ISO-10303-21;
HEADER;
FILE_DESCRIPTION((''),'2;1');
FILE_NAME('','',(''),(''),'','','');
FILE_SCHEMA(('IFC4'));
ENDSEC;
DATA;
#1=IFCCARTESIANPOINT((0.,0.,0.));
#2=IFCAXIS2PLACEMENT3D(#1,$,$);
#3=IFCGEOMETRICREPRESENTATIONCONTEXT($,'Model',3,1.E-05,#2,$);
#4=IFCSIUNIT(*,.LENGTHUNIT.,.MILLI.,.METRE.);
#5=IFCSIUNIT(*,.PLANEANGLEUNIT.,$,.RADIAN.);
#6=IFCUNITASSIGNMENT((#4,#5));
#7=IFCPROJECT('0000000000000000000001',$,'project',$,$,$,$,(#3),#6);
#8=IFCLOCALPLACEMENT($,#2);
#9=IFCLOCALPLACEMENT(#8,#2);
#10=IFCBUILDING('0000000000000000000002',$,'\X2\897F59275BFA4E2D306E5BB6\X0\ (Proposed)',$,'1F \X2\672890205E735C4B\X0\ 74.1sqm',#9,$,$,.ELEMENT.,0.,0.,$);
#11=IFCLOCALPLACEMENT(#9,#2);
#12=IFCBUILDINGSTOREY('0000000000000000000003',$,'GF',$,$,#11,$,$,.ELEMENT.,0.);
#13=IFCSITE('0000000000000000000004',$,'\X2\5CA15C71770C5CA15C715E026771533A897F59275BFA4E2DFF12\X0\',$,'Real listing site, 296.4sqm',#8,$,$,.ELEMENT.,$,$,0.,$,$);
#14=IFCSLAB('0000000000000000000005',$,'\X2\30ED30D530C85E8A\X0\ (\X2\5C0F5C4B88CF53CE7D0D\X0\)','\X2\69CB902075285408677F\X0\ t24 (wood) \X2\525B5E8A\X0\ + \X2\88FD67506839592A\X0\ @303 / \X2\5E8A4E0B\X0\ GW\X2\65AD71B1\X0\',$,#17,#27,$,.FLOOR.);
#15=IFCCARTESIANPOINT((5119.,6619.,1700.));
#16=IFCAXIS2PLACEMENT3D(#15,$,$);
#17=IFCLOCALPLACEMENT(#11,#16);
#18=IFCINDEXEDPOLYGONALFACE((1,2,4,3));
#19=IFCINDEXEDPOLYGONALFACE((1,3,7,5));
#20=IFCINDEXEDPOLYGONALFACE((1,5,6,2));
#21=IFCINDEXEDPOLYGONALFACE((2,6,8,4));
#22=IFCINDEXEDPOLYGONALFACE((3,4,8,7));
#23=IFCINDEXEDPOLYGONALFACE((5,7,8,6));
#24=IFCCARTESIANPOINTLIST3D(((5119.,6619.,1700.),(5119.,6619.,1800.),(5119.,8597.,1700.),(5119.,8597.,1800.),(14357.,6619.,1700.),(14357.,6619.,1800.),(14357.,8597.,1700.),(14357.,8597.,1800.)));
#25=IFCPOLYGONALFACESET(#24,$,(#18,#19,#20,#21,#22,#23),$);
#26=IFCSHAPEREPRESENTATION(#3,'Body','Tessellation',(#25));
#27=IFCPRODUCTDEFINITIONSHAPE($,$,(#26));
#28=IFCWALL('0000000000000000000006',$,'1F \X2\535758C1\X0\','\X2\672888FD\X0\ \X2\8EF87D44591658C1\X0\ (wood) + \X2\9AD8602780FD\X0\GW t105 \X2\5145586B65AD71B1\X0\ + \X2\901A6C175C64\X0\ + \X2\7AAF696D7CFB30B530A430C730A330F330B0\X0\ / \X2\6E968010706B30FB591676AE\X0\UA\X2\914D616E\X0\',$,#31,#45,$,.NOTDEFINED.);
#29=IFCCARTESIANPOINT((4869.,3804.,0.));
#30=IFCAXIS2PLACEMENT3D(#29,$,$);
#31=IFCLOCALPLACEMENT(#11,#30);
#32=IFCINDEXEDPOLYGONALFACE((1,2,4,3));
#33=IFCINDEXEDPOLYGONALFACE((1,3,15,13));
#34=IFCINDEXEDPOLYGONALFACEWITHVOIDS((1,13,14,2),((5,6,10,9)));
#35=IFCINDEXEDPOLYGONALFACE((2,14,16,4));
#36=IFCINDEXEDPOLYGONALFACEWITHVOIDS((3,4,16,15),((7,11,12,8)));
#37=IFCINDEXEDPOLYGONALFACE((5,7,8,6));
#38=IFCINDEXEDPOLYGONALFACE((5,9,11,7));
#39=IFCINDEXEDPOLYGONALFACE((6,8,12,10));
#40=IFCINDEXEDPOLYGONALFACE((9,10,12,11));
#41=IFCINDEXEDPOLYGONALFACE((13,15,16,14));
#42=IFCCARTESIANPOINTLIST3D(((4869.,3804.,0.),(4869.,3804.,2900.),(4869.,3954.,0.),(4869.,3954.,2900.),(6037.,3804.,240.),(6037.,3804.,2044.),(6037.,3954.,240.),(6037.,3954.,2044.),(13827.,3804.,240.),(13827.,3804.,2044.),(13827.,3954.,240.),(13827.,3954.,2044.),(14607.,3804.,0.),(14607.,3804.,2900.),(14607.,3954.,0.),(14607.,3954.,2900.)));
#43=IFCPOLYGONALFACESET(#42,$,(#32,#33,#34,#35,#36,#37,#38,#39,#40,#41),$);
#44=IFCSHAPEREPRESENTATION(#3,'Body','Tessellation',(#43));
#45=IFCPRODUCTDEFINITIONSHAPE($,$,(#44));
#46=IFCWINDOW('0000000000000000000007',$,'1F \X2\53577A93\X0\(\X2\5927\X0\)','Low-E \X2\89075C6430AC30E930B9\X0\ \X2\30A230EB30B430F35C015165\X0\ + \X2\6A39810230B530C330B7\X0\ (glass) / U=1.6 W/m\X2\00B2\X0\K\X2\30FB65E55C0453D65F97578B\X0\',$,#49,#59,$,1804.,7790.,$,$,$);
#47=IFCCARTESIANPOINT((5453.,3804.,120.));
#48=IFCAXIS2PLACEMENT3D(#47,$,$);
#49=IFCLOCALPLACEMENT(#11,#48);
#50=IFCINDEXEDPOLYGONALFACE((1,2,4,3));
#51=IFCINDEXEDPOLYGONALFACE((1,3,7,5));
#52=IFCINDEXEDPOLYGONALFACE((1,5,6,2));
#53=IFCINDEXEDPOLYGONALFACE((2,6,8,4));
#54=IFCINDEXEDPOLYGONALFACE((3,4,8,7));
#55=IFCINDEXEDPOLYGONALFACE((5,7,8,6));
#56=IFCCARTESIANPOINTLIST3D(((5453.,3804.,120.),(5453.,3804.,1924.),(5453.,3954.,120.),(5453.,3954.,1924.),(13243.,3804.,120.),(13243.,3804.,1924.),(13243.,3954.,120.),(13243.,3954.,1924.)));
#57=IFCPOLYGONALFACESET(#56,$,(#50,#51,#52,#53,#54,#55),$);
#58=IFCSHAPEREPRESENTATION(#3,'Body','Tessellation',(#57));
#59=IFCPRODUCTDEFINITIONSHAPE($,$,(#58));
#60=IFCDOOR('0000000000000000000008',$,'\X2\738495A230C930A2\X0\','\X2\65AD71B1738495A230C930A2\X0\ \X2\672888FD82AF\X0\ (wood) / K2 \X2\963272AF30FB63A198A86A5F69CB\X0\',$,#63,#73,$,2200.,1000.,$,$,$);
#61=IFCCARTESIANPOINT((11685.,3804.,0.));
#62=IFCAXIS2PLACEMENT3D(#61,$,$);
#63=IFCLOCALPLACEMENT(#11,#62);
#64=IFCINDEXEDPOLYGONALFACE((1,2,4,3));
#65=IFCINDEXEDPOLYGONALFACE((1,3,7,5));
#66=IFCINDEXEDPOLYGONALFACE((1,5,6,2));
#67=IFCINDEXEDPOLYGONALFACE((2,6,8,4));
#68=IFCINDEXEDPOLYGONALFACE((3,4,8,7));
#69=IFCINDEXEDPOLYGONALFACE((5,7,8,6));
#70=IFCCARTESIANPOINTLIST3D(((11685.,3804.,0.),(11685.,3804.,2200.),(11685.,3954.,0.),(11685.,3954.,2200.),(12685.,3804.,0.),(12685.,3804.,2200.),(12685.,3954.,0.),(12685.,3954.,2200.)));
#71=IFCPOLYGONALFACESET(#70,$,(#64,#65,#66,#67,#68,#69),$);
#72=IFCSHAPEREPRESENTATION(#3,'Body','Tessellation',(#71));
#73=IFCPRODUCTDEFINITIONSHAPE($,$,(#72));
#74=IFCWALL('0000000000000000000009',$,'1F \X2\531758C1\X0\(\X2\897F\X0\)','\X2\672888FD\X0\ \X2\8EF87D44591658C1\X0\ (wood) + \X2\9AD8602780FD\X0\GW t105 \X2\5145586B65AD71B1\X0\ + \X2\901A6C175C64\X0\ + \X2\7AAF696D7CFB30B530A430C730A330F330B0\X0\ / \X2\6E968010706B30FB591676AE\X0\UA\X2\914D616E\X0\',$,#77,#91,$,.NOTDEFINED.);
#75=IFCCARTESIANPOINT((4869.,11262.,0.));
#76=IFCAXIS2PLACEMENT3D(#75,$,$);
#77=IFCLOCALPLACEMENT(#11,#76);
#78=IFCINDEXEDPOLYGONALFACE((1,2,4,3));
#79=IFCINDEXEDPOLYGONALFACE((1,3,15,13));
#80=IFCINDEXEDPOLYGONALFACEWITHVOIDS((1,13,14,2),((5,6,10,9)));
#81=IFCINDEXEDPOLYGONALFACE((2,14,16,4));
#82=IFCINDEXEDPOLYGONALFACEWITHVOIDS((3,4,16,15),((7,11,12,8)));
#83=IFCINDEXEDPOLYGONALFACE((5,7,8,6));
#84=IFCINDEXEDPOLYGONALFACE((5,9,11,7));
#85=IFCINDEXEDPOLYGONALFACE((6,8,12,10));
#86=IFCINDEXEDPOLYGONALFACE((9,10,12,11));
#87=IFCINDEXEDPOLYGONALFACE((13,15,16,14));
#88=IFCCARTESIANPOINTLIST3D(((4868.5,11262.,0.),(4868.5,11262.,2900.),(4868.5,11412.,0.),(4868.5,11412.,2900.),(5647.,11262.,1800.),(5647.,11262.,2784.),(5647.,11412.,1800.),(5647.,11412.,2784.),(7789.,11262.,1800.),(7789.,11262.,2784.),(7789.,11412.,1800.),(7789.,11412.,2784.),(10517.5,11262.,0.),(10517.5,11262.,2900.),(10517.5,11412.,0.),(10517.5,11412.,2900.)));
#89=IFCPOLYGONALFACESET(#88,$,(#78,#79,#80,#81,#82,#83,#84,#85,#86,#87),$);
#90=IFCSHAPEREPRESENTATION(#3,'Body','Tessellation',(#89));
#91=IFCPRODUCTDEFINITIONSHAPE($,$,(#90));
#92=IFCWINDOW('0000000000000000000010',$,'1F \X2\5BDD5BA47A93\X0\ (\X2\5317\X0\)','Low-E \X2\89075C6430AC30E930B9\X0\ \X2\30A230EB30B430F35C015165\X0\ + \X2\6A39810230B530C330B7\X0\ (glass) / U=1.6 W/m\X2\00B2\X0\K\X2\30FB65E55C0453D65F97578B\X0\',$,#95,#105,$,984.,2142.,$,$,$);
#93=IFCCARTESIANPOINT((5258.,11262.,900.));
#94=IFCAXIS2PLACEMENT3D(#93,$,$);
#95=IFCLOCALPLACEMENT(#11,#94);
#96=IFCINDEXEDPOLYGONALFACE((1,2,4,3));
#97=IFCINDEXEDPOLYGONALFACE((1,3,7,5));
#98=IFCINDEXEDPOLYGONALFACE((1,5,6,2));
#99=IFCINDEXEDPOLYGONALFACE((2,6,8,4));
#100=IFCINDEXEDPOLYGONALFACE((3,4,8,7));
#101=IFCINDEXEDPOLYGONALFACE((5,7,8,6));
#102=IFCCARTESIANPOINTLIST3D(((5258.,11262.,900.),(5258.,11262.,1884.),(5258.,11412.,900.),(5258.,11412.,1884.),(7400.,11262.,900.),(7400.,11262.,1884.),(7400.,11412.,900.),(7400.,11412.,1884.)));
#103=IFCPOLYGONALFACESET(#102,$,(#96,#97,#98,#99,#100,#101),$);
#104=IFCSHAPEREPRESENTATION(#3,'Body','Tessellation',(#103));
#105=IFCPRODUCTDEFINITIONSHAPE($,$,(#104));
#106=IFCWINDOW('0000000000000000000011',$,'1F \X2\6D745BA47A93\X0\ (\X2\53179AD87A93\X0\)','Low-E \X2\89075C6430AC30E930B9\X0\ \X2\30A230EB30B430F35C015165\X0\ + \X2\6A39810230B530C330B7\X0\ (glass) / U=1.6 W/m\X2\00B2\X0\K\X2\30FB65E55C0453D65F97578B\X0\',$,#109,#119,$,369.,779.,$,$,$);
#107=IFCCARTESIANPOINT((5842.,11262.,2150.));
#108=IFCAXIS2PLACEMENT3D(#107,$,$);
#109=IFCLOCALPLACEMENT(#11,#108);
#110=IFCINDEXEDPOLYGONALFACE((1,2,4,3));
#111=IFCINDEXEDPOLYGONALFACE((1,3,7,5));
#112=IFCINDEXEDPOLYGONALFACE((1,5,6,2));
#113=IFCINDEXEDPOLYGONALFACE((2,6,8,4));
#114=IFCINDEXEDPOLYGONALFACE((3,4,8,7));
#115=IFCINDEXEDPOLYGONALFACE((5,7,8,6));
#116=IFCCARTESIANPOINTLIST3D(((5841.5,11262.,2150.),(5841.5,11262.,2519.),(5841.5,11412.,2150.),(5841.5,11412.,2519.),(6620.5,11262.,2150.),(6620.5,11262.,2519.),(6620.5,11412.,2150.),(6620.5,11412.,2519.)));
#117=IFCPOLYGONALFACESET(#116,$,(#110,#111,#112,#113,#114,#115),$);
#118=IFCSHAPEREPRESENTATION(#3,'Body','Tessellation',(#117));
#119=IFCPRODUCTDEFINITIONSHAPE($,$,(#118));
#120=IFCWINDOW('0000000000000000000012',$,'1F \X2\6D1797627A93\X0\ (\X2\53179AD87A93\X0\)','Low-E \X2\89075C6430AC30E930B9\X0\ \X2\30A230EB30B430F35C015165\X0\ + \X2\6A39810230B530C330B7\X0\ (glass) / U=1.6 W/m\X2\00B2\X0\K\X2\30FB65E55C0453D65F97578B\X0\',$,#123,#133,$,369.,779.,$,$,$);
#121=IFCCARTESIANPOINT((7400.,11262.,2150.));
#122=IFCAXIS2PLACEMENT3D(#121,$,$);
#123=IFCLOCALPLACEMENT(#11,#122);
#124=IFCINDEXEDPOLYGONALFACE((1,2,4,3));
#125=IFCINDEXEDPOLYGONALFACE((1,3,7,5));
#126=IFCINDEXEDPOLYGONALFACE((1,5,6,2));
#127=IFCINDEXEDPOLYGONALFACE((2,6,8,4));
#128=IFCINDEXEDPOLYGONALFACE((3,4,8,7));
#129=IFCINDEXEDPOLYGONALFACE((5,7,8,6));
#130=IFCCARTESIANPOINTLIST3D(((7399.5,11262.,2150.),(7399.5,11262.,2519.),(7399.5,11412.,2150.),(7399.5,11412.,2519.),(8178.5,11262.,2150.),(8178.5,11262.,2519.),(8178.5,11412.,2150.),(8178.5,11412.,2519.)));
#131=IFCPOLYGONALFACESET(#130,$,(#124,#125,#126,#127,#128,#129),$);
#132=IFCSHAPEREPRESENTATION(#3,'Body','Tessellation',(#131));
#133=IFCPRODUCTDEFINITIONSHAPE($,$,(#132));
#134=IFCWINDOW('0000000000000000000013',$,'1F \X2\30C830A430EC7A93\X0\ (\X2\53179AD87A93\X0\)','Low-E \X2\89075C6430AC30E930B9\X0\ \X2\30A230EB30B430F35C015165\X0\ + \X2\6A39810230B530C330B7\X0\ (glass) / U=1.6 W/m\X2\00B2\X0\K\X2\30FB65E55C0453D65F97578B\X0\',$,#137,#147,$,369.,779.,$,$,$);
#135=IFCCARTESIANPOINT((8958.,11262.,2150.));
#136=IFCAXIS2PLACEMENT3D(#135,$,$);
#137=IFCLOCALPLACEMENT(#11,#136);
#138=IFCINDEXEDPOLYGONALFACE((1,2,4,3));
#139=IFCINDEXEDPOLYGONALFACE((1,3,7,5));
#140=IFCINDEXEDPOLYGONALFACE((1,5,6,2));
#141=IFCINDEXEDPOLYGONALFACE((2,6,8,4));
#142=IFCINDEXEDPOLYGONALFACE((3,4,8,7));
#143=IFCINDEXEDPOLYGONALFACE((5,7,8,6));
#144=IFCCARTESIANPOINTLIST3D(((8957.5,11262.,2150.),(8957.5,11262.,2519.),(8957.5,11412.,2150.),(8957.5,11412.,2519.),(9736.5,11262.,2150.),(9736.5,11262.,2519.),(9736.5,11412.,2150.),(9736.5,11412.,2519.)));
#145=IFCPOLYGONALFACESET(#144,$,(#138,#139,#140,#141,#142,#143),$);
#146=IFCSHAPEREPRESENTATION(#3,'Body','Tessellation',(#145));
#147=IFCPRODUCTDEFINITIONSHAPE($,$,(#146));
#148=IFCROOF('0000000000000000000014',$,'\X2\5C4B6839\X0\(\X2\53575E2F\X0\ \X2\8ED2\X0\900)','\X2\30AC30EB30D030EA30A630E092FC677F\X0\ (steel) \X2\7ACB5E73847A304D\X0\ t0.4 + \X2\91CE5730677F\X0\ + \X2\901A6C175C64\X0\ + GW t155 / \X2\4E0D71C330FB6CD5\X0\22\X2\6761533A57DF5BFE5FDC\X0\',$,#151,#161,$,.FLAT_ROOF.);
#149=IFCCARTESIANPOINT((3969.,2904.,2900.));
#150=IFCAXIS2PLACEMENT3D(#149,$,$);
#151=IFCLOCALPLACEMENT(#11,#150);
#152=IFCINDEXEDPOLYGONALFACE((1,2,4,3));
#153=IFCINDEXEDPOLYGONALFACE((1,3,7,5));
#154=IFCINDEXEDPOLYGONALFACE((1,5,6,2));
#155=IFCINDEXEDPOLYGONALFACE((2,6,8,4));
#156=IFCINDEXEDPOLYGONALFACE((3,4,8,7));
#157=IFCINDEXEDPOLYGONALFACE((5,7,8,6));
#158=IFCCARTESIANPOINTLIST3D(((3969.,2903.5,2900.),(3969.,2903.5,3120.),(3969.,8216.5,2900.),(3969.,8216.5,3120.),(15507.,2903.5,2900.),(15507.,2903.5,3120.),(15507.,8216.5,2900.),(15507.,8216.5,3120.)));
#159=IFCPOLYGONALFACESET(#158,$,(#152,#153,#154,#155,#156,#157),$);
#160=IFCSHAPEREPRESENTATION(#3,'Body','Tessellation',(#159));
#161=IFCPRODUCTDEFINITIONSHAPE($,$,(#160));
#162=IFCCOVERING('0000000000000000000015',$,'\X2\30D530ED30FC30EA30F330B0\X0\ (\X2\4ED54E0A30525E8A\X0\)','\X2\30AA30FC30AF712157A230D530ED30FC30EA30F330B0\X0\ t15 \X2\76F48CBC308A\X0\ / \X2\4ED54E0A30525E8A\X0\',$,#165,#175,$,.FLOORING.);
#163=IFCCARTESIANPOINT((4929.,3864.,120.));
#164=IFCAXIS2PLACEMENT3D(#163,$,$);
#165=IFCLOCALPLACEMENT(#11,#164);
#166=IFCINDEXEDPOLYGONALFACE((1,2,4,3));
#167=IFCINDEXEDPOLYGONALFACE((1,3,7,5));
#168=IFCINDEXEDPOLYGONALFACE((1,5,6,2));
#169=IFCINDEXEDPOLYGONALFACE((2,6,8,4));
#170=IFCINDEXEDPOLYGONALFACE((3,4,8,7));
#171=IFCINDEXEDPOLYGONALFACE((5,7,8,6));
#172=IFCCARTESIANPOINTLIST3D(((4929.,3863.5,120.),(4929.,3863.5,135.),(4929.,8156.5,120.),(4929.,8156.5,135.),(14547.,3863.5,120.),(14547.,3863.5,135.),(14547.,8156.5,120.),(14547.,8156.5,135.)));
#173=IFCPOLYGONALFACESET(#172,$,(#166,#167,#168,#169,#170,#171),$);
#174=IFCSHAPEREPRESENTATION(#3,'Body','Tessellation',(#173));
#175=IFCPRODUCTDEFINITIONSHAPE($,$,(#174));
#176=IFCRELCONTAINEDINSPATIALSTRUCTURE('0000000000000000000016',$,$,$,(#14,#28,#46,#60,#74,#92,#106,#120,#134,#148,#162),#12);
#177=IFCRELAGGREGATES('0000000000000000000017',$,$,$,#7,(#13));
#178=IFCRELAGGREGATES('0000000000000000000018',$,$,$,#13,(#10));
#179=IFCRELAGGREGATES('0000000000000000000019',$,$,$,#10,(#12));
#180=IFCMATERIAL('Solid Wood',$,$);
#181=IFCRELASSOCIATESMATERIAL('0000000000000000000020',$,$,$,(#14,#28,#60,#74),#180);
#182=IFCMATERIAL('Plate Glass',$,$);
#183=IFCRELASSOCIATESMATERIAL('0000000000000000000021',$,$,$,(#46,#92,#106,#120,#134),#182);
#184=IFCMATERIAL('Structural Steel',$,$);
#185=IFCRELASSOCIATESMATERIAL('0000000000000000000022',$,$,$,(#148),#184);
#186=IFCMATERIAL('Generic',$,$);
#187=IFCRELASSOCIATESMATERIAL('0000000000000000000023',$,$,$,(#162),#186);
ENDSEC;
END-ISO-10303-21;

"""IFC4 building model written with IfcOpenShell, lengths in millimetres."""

from ifc_helpers import new_model, si_unit, frame, frame_2d, origin, place, context, project, spatial, rectangle, extrude, material, element, fill, save


model = new_model("IFC4")

# Units and contexts
model_context = context("Model", 3, precision=1e-05, world=origin())
ifc_project = project(units=[si_unit("LENGTHUNIT", "METRE", prefix="MILLI"), si_unit("PLANEANGLEUNIT", "RADIAN")], contexts=[model_context])

# Site, building, storey
site_placement = place(None, origin())
site = spatial("IfcSite", under=ifc_project, at=site_placement, Name="岡山県岡山市東区西大寺中２", ObjectType="Real listing site, 296.4sqm", CompositionType="ELEMENT", RefElevation=0.0)
building_placement = place(site_placement, origin())
building = spatial("IfcBuilding", under=site, at=building_placement, Name="西大寺中の家 (Proposed)", ObjectType="1F 木造平屋 74.1sqm", CompositionType="ELEMENT", ElevationOfRefHeight=0.0, ElevationOfTerrain=0.0)
storey_placement = place(building_placement, origin())
storey = spatial("IfcBuildingStorey", under=building, at=storey_placement, Name="GF", CompositionType="ELEMENT", Elevation=0.0)

# Slab
ifc_material_1 = material(Name="Solid Wood")
slab_1_placement = place(storey_placement, frame((5119.0, 6619.0, 1700.0)))
element("IfcSlab", 1, at=slab_1_placement, inside=storey, material=ifc_material_1, Name="ロフト床 (小屋裏収納)", Description="構造用合板 t24 (wood) 剛床 + 製材根太 @303 / 床下 GW断熱", PredefinedType="FLOOR", context=model_context, shape_type="SweptSolid", body=[
    extrude(rectangle(XDim=9238.0, YDim=1978.0, at=frame_2d((4619.0, 989.0))), frame((5119.0, 6619.0, 1700.0)), (0.0, 0.0, 1.0), 100.0),
])

# Wall, openings, window, door
wall_1_placement = place(storey_placement, frame((4869.0, 3804.0, 0.0)))
wall_1 = element("IfcWall", 2, at=wall_1_placement, inside=storey, material=ifc_material_1, Name="1F 南壁", Description="木製 軸組外壁 (wood) + 高性能GW t105 充填断熱 + 通気層 + 窯業系サイディング / 準耐火・外皮UA配慮", PredefinedType="NOTDEFINED", context=model_context, shape_type="SweptSolid", body=[
    extrude(rectangle(XDim=9738.0, YDim=150.0, at=frame_2d((4869.0, 75.0))), frame((4869.0, 3804.0, 0.0)), (0.0, 0.0, 1.0), 2900.0),
])
opening_1_placement = place(storey_placement, frame((5453.0, 3804.0, 120.0)))
opening_1 = element("IfcOpeningElement", 3, at=opening_1_placement, cuts=wall_1, PredefinedType="NOTDEFINED", context=model_context, shape_type="SweptSolid", body=[
    extrude(rectangle(XDim=7790.0, YDim=150.0, at=frame_2d((3895.0, 75.0))), frame((5453.0, 3804.0, 120.0)), (0.0, 0.0, 1.0), 1804.0),
])
opening_2_placement = place(storey_placement, frame((11685.0, 3804.0, 0.0)))
opening_2 = element("IfcOpeningElement", 4, at=opening_2_placement, cuts=wall_1, PredefinedType="NOTDEFINED", context=model_context, shape_type="SweptSolid", body=[
    extrude(rectangle(XDim=1000.0, YDim=150.0, at=frame_2d((500.0, 75.0))), frame((11685.0, 3804.0, 0.0)), (0.0, 0.0, 1.0), 2200.0),
])
ifc_material_2 = material(Name="Plate Glass")
window_1_placement = place(storey_placement, frame((5453.0, 3804.0, 120.0)))
window_1 = element("IfcWindow", 5, at=window_1_placement, inside=storey, material=ifc_material_2, Name="1F 南窓(大)", Description="Low-E 複層ガラス アルゴン封入 + 樹脂サッシ (glass) / U=1.6 W/m²K・日射取得型", OverallHeight=1804.0, OverallWidth=7790.0, context=model_context, shape_type="SweptSolid", body=[
    extrude(rectangle(XDim=7790.0, YDim=150.0, at=frame_2d((3895.0, 75.0))), frame((5453.0, 3804.0, 120.0)), (0.0, 0.0, 1.0), 1804.0),
])
fill(opening_1, window_1)
door_placement = place(storey_placement, frame((11685.0, 3804.0, 0.0)))
door = element("IfcDoor", 6, at=door_placement, inside=storey, material=ifc_material_1, Name="玄関ドア", Description="断熱玄関ドア 木製芯 (wood) / K2 防犯・採風機構", OverallHeight=2200.0, OverallWidth=1000.0, context=model_context, shape_type="SweptSolid", body=[
    extrude(rectangle(XDim=1000.0, YDim=150.0, at=frame_2d((500.0, 75.0))), frame((11685.0, 3804.0, 0.0)), (0.0, 0.0, 1.0), 2200.0),
])
fill(opening_2, door)

# Wall, openings, windows
wall_2_placement = place(storey_placement, frame((4869.0, 11262.0, 0.0)))
wall_2 = element("IfcWall", 7, at=wall_2_placement, inside=storey, material=ifc_material_1, Name="1F 北壁(西)", Description="木製 軸組外壁 (wood) + 高性能GW t105 充填断熱 + 通気層 + 窯業系サイディング / 準耐火・外皮UA配慮", PredefinedType="NOTDEFINED", context=model_context, shape_type="SweptSolid", body=[
    extrude(rectangle(XDim=5649.0, YDim=150.0, at=frame_2d((2824.0, 75.0))), frame((4869.0, 11262.0, 0.0)), (0.0, 0.0, 1.0), 2900.0),
])
opening_3_placement = place(storey_placement, frame((5258.0, 11262.0, 900.0)))
opening_3 = element("IfcOpeningElement", 8, at=opening_3_placement, cuts=wall_2, PredefinedType="NOTDEFINED", context=model_context, shape_type="SweptSolid", body=[
    extrude(rectangle(XDim=2142.0, YDim=150.0, at=frame_2d((1071.0, 75.0))), frame((5258.0, 11262.0, 900.0)), (0.0, 0.0, 1.0), 984.0),
])
opening_4_placement = place(storey_placement, frame((5842.0, 11262.0, 2150.0)))
opening_4 = element("IfcOpeningElement", 9, at=opening_4_placement, cuts=wall_2, PredefinedType="NOTDEFINED", context=model_context, shape_type="SweptSolid", body=[
    extrude(rectangle(XDim=779.0, YDim=150.0, at=frame_2d((389.0, 75.0))), frame((5842.0, 11262.0, 2150.0)), (0.0, 0.0, 1.0), 369.0),
])
opening_5_placement = place(storey_placement, frame((7400.0, 11262.0, 2150.0)))
opening_5 = element("IfcOpeningElement", 10, at=opening_5_placement, cuts=wall_2, PredefinedType="NOTDEFINED", context=model_context, shape_type="SweptSolid", body=[
    extrude(rectangle(XDim=779.0, YDim=150.0, at=frame_2d((389.0, 75.0))), frame((7400.0, 11262.0, 2150.0)), (0.0, 0.0, 1.0), 369.0),
])
opening_6_placement = place(storey_placement, frame((8958.0, 11262.0, 2150.0)))
opening_6 = element("IfcOpeningElement", 11, at=opening_6_placement, cuts=wall_2, PredefinedType="NOTDEFINED", context=model_context, shape_type="SweptSolid", body=[
    extrude(rectangle(XDim=779.0, YDim=150.0, at=frame_2d((389.0, 75.0))), frame((8958.0, 11262.0, 2150.0)), (0.0, 0.0, 1.0), 369.0),
])
window_2_placement = place(storey_placement, frame((5258.0, 11262.0, 900.0)))
window_2 = element("IfcWindow", 12, at=window_2_placement, inside=storey, material=ifc_material_2, Name="1F 寝室窓 (北)", Description="Low-E 複層ガラス アルゴン封入 + 樹脂サッシ (glass) / U=1.6 W/m²K・日射取得型", OverallHeight=984.0, OverallWidth=2142.0, context=model_context, shape_type="SweptSolid", body=[
    extrude(rectangle(XDim=2142.0, YDim=150.0, at=frame_2d((1071.0, 75.0))), frame((5258.0, 11262.0, 900.0)), (0.0, 0.0, 1.0), 984.0),
])
fill(opening_3, window_2)
window_3_placement = place(storey_placement, frame((5842.0, 11262.0, 2150.0)))
window_3 = element("IfcWindow", 13, at=window_3_placement, inside=storey, material=ifc_material_2, Name="1F 浴室窓 (北高窓)", Description="Low-E 複層ガラス アルゴン封入 + 樹脂サッシ (glass) / U=1.6 W/m²K・日射取得型", OverallHeight=369.0, OverallWidth=779.0, context=model_context, shape_type="SweptSolid", body=[
    extrude(rectangle(XDim=779.0, YDim=150.0, at=frame_2d((389.0, 75.0))), frame((5842.0, 11262.0, 2150.0)), (0.0, 0.0, 1.0), 369.0),
])
fill(opening_4, window_3)
window_4_placement = place(storey_placement, frame((7400.0, 11262.0, 2150.0)))
window_4 = element("IfcWindow", 14, at=window_4_placement, inside=storey, material=ifc_material_2, Name="1F 洗面窓 (北高窓)", Description="Low-E 複層ガラス アルゴン封入 + 樹脂サッシ (glass) / U=1.6 W/m²K・日射取得型", OverallHeight=369.0, OverallWidth=779.0, context=model_context, shape_type="SweptSolid", body=[
    extrude(rectangle(XDim=779.0, YDim=150.0, at=frame_2d((389.0, 75.0))), frame((7400.0, 11262.0, 2150.0)), (0.0, 0.0, 1.0), 369.0),
])
fill(opening_5, window_4)
window_5_placement = place(storey_placement, frame((8958.0, 11262.0, 2150.0)))
window_5 = element("IfcWindow", 15, at=window_5_placement, inside=storey, material=ifc_material_2, Name="1F トイレ窓 (北高窓)", Description="Low-E 複層ガラス アルゴン封入 + 樹脂サッシ (glass) / U=1.6 W/m²K・日射取得型", OverallHeight=369.0, OverallWidth=779.0, context=model_context, shape_type="SweptSolid", body=[
    extrude(rectangle(XDim=779.0, YDim=150.0, at=frame_2d((389.0, 75.0))), frame((8958.0, 11262.0, 2150.0)), (0.0, 0.0, 1.0), 369.0),
])
fill(opening_6, window_5)

# Roof
ifc_material_3 = material(Name="Structural Steel")
roof_1_placement = place(storey_placement, frame((3969.0, 2904.0, 2900.0)))
element("IfcRoof", 16, at=roof_1_placement, inside=storey, material=ifc_material_3, Name="屋根(南帯 軒900)", Description="ガルバリウム鋼板 (steel) 立平葺き t0.4 + 野地板 + 通気層 + GW t155 / 不燃・法22条区域対応", PredefinedType="FLAT_ROOF", context=model_context, shape_type="SweptSolid", body=[
    extrude(rectangle(XDim=11538.0, YDim=5313.0, at=frame_2d((5769.0, 2656.0))), frame((3969.0, 2904.0, 2900.0)), (0.0, 0.0, 1.0), 220.0),
])

# Covering
ifc_material_4 = material(Name="Generic")
covering_1_placement = place(storey_placement, frame((4929.0, 3864.0, 120.0)))
element("IfcCovering", 17, at=covering_1_placement, inside=storey, material=ifc_material_4, Name="フローリング (仕上げ床)", Description="オーク無垢フローリング t15 直貼り / 仕上げ床", PredefinedType="FLOORING", context=model_context, shape_type="SweptSolid", body=[
    extrude(rectangle(XDim=9618.0, YDim=4293.0, at=frame_2d((4809.0, 2146.0))), frame((4929.0, 3864.0, 120.0)), (0.0, 0.0, 1.0), 15.0),
])

save(model, "model.ifc")
